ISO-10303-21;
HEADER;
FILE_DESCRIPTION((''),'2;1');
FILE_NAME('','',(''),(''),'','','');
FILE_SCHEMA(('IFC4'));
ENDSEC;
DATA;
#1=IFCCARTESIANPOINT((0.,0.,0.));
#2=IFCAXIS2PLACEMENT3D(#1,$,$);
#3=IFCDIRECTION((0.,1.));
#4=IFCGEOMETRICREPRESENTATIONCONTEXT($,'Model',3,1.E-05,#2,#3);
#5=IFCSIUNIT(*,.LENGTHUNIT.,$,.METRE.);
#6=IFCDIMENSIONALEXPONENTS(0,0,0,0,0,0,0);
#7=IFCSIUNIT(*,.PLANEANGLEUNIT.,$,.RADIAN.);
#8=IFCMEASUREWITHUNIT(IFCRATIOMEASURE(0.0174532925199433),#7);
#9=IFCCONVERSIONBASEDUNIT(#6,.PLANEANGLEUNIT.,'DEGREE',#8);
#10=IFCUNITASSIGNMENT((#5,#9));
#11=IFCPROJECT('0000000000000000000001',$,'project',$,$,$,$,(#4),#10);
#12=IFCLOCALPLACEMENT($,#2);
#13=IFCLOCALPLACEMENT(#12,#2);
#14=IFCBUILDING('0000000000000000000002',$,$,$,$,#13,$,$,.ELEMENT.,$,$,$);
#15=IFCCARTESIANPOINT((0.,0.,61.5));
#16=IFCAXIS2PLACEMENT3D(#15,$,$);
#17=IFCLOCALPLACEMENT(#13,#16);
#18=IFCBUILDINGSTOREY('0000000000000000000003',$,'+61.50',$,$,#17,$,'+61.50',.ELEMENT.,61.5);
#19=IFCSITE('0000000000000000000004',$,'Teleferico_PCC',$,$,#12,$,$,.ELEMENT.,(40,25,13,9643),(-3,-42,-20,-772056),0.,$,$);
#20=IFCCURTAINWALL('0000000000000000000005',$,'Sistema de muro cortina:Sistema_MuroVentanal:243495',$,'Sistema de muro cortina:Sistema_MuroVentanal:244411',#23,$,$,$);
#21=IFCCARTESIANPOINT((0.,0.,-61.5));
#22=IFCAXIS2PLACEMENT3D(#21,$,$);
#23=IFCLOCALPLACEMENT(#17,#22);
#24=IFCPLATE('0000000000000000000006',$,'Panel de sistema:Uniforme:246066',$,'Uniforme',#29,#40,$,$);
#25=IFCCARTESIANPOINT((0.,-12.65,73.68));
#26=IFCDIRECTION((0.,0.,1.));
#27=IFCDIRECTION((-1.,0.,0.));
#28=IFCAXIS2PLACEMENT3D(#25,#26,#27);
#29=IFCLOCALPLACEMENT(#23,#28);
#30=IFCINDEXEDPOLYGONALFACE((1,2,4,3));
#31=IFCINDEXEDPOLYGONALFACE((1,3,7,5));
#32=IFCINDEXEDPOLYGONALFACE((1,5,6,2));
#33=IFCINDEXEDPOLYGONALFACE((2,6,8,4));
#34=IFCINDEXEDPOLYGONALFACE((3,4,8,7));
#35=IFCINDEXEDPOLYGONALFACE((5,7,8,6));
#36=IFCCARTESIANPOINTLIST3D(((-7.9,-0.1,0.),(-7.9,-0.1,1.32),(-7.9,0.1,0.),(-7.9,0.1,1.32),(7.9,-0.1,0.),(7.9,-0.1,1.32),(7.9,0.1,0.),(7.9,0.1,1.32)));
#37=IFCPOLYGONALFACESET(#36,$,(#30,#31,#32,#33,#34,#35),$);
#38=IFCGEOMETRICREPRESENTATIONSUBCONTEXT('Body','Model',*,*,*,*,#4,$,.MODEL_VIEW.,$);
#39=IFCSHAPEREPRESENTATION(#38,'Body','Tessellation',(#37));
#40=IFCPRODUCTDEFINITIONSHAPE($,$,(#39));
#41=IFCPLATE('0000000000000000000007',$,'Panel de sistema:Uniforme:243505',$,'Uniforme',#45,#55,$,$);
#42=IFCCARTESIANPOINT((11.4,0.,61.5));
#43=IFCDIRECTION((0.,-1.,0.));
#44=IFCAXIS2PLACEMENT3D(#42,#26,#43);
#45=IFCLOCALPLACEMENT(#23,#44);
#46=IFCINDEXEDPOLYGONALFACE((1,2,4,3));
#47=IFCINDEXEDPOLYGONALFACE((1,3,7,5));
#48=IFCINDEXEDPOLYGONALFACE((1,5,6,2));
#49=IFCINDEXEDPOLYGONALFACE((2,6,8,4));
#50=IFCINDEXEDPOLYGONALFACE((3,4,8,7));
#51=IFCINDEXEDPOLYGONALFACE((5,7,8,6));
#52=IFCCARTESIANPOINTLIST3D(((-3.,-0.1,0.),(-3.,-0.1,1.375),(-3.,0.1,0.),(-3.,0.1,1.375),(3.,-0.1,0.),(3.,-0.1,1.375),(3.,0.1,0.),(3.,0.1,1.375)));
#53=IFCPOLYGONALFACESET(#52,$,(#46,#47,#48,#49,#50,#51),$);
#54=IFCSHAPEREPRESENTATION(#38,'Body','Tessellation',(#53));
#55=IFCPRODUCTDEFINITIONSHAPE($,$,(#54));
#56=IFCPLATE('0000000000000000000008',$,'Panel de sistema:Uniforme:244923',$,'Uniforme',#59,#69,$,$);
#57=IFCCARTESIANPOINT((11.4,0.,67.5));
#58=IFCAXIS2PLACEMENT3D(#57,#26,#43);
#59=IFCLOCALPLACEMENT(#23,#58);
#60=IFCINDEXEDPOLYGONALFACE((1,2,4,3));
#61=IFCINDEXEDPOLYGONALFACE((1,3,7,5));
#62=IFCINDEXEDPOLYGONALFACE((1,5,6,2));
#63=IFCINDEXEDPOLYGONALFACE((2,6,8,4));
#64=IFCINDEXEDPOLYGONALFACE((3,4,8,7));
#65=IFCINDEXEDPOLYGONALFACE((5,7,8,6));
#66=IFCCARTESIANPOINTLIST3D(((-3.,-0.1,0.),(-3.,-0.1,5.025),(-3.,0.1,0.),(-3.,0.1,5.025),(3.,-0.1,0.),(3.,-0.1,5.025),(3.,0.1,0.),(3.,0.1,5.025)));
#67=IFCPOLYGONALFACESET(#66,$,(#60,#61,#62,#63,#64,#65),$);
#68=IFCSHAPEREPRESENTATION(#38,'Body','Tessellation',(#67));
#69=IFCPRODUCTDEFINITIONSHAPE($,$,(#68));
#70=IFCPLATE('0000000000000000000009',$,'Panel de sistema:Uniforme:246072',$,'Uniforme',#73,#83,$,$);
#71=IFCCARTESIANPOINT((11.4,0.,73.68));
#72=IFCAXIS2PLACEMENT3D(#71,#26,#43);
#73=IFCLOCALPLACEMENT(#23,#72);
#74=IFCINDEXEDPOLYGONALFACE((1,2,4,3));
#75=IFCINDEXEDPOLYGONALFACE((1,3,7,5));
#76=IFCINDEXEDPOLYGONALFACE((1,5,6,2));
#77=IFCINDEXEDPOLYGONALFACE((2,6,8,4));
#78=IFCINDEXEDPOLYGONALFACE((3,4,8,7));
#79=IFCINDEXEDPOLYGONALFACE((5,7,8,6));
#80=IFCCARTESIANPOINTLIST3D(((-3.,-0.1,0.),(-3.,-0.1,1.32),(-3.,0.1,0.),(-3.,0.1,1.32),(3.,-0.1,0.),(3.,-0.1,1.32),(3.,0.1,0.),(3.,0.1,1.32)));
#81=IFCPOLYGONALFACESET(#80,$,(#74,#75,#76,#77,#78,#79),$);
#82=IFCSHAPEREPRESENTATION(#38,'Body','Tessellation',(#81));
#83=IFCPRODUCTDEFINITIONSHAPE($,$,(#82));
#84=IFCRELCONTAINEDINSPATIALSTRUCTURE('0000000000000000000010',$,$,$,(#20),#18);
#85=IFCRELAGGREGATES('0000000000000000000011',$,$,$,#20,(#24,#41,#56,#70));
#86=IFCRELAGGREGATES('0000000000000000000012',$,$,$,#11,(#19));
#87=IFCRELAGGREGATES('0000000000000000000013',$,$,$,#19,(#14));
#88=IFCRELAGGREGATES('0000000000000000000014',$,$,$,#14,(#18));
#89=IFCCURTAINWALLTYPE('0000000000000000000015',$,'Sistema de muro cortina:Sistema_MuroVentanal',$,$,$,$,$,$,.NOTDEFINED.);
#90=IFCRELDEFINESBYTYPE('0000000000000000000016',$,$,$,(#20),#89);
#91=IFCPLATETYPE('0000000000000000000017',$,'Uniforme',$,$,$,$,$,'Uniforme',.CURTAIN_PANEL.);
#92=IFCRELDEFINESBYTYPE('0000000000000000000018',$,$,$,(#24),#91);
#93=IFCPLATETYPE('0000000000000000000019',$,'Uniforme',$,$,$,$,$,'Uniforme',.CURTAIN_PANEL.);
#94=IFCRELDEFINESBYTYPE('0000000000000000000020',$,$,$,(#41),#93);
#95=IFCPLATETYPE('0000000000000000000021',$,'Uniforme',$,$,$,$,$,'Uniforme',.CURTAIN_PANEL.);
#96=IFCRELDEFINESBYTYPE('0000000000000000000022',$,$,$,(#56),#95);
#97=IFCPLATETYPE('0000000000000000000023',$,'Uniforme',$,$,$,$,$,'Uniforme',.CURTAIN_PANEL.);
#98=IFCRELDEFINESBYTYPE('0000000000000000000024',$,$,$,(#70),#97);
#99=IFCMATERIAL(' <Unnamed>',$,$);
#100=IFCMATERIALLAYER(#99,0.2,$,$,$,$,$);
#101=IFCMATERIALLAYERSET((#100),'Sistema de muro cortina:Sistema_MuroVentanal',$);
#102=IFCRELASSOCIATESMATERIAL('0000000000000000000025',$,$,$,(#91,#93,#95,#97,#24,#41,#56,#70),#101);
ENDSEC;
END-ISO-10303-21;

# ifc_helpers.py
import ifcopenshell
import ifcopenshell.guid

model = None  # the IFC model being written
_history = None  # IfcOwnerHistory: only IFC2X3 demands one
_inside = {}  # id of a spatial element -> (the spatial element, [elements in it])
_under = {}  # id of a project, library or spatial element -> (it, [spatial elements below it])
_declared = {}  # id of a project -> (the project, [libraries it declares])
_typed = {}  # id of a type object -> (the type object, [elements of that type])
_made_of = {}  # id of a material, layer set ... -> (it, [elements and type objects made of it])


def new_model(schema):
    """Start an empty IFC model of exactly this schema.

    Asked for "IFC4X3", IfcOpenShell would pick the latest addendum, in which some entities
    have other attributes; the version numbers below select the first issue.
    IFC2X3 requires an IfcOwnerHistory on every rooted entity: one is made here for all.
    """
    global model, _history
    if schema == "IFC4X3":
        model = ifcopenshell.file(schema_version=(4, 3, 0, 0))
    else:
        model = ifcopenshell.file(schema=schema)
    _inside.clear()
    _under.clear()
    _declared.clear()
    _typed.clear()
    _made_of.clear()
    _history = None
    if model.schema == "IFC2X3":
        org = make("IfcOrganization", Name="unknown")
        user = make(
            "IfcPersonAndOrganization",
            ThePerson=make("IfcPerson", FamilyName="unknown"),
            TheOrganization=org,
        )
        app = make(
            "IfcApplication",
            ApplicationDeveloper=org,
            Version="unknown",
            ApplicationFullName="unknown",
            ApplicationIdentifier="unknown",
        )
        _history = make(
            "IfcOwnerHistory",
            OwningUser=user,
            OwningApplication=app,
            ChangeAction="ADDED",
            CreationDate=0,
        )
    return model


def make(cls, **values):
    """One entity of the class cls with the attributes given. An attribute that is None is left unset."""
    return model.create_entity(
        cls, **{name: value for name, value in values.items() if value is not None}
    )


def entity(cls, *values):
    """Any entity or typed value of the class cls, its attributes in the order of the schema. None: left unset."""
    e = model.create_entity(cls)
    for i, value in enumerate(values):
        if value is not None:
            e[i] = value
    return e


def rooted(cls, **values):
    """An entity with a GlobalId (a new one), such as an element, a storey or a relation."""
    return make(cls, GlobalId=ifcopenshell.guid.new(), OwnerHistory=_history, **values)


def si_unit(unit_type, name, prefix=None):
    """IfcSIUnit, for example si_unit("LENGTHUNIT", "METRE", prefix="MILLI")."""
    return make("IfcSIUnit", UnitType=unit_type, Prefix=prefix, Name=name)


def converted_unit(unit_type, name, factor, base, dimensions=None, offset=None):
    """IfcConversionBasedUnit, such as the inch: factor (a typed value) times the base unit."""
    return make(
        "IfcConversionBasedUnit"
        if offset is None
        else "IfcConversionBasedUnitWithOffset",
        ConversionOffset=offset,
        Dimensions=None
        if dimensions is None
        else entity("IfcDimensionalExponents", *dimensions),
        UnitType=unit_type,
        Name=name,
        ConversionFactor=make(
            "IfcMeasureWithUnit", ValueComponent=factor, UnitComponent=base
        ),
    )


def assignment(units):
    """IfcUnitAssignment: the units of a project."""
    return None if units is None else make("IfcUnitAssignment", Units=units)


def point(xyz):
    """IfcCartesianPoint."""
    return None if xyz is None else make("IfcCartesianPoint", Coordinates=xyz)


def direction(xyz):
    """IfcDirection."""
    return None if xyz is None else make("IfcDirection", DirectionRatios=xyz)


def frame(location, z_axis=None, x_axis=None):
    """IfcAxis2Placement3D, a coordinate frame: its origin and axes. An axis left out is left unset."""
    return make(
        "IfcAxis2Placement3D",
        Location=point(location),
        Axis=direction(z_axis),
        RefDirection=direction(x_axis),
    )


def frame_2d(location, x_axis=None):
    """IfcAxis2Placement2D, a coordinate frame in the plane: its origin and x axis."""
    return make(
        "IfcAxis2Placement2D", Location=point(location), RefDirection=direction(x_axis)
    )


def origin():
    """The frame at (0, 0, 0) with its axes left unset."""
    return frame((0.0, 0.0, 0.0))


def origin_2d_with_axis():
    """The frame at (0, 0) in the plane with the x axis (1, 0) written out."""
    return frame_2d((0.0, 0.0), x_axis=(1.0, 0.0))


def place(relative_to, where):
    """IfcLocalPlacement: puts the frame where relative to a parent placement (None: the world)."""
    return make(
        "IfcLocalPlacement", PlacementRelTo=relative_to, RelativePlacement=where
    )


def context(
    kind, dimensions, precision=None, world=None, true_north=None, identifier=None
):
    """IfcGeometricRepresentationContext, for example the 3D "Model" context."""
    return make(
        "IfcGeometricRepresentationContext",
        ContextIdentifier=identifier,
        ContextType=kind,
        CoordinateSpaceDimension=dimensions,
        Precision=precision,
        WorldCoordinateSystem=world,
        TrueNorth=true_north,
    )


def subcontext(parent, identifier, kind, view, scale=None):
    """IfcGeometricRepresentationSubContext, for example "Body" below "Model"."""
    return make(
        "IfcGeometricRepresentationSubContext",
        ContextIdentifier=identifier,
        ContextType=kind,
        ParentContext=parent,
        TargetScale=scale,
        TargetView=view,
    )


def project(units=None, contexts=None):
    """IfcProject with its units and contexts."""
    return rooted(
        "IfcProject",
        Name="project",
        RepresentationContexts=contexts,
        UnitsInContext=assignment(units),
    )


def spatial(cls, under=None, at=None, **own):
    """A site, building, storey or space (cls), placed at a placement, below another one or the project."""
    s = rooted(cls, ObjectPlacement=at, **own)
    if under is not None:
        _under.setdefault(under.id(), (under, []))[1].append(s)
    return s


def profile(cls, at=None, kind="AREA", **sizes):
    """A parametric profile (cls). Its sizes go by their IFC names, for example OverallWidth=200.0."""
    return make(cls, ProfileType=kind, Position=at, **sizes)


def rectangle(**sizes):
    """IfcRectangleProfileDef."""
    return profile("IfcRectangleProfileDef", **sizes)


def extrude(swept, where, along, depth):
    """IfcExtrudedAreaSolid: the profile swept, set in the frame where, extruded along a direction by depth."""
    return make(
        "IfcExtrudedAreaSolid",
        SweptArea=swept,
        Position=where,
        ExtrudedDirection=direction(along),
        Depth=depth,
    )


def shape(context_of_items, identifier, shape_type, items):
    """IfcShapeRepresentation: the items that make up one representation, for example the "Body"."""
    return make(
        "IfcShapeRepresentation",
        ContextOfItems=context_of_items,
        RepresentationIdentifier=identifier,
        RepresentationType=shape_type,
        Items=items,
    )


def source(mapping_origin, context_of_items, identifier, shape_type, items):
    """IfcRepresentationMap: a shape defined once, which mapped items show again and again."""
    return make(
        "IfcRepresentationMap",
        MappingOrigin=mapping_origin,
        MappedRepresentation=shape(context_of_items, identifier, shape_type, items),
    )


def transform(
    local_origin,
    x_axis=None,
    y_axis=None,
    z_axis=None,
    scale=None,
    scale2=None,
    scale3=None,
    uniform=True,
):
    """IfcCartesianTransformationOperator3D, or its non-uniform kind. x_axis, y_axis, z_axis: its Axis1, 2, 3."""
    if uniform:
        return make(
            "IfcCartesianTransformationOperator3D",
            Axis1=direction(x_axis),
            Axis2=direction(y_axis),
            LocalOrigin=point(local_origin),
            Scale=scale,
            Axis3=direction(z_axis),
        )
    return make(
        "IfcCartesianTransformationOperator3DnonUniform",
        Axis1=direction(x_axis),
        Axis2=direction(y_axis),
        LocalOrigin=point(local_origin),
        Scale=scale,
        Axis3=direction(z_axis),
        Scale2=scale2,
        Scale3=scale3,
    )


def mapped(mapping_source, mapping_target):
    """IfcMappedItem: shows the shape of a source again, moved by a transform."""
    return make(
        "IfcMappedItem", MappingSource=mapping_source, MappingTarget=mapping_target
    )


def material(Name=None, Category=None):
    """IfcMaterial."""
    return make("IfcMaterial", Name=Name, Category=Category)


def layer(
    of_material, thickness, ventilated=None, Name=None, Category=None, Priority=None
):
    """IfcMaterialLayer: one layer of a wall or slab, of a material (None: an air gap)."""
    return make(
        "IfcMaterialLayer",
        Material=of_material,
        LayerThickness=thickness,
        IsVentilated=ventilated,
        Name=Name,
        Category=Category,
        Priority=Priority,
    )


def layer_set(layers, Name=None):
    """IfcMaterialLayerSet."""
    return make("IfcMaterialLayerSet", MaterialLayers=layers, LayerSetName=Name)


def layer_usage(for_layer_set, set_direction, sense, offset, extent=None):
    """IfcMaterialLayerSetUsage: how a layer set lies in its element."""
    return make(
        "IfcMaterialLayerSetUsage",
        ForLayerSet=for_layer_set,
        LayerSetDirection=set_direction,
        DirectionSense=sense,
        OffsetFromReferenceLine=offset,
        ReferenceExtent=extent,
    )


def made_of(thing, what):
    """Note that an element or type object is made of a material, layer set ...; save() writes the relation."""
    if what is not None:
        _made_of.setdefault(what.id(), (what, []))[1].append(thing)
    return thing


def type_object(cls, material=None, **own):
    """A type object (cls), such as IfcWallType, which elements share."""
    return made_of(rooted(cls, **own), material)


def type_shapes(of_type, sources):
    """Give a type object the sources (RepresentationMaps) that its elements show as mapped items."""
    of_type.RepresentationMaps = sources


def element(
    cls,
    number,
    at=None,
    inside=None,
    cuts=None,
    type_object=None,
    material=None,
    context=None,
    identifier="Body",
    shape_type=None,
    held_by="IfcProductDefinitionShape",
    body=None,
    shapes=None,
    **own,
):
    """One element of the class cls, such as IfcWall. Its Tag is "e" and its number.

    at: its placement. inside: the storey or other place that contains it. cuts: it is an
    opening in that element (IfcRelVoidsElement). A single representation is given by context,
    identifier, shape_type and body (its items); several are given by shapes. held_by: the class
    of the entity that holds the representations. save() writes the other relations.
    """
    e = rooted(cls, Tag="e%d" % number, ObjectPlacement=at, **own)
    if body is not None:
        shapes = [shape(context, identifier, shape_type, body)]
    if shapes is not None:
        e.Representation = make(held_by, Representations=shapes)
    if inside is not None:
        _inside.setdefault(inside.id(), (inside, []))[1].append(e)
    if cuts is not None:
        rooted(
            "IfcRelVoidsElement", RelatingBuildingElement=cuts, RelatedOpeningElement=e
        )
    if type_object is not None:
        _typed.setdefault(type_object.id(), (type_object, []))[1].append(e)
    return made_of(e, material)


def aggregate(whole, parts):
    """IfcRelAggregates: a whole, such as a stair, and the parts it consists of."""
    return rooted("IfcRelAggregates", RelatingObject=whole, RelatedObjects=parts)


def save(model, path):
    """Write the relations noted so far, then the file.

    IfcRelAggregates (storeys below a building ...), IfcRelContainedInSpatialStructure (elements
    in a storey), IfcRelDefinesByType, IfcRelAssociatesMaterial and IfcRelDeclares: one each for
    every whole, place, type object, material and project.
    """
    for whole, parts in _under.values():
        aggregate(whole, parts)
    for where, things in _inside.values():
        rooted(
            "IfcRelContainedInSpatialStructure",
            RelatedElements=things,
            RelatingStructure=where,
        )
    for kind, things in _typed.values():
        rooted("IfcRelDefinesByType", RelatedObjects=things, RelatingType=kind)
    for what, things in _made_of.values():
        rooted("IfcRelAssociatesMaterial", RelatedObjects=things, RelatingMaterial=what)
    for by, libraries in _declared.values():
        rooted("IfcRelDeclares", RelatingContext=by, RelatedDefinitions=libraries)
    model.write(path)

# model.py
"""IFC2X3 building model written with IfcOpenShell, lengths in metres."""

from ifc_helpers import new_model, entity, si_unit, converted_unit, direction, frame, origin, origin_2d_with_axis, place, context, subcontext, project, spatial, rectangle, extrude, source, transform, mapped, material, layer, layer_set, layer_usage, type_object, type_shapes, element, aggregate, save


model = new_model("IFC2X3")

# Units and contexts
model_context = context("Model", 3, precision=1e-05, world=origin(), true_north=direction((0.0, 1.0)))
body_context = subcontext(model_context, "Body", "Model", "MODEL_VIEW")
ifc_project = project(units=[si_unit("LENGTHUNIT", "METRE"), converted_unit("PLANEANGLEUNIT", "DEGREE", entity("IfcRatioMeasure", 0.0174532925199433), si_unit("PLANEANGLEUNIT", "RADIAN"), dimensions=[0, 0, 0, 0, 0, 0, 0])], contexts=[model_context])

# Site, building, storey
site_placement = place(None, origin())
site = spatial("IfcSite", under=ifc_project, at=site_placement, Name="Teleferico_PCC", CompositionType="ELEMENT", RefLatitude=(40, 25, 13, 9643), RefLongitude=(-3, -42, -20, -772056), RefElevation=0.0)
building_placement = place(site_placement, origin())
building = spatial("IfcBuilding", under=site, at=building_placement, CompositionType="ELEMENT")
storey_placement = place(building_placement, frame((0.0, 0.0, 61.5)))
storey = spatial("IfcBuildingStorey", under=building, at=storey_placement, Name="+61.50", LongName="+61.50", CompositionType="ELEMENT", Elevation=61.5)

# Curtain wall, plates
curtain_wall_type = type_object("IfcCurtainWallType", Name="Sistema de muro cortina:Sistema_MuroVentanal", PredefinedType="NOTDEFINED")
curtain_wall_placement = place(storey_placement, frame((0.0, 0.0, -61.5)))
curtain_wall = element("IfcCurtainWall", 1, at=curtain_wall_placement, inside=storey, type_object=curtain_wall_type, Name="Sistema de muro cortina:Sistema_MuroVentanal:243495", ObjectType="Sistema de muro cortina:Sistema_MuroVentanal:244411")
ifc_material = material(Name=" <Unnamed>")
ifc_layer_1 = layer(ifc_material, 0.2)
ifc_layer_set_1 = layer_set([ifc_layer_1], Name="Sistema de muro cortina:Sistema_MuroVentanal")
ifc_layer_usage_1 = layer_usage(ifc_layer_set_1, "AXIS3", "POSITIVE", 0.0)
plate_type_1 = type_object("IfcPlateType", Name="Uniforme", ElementType="Uniforme", PredefinedType="CURTAIN_PANEL", material=ifc_layer_set_1)
shared_shape_1 = source(origin(), body_context, "Body", "SweptSolid", [
    extrude(rectangle(XDim=0.2, YDim=15.8, at=origin_2d_with_axis()), frame((0.0, 0.0, 0.0), z_axis=(0.0, 0.0, 1.0), x_axis=(0.0, 1.0, 0.0)), (0.0, 0.0, 1.0), 1.32),
])
type_shapes(plate_type_1, [shared_shape_1])
plate_1_placement = place(curtain_wall_placement, frame((0.0, -12.65, 73.68), z_axis=(0.0, 0.0, 1.0), x_axis=(-1.0, 0.0, 0.0)))
plate_1 = element("IfcPlate", 2, at=plate_1_placement, type_object=plate_type_1, material=ifc_layer_usage_1, Name="Panel de sistema:Uniforme:246066", ObjectType="Uniforme", context=body_context, shape_type="MappedRepresentation", body=[
    mapped(shared_shape_1, transform((0.0, 0.0, 0.0), scale=1.0)),
])
ifc_layer_usage_2 = layer_usage(ifc_layer_set_1, "AXIS3", "POSITIVE", 0.0)
plate_type_2 = type_object("IfcPlateType", Name="Uniforme", ElementType="Uniforme", PredefinedType="CURTAIN_PANEL", material=ifc_layer_set_1)
shared_shape_2 = source(origin(), body_context, "Body", "SweptSolid", [
    extrude(rectangle(XDim=0.2, YDim=6.0, at=origin_2d_with_axis()), frame((0.0, 0.0, 0.0), z_axis=(0.0, 0.0, 1.0), x_axis=(0.0, 1.0, 0.0)), (0.0, 0.0, 1.0), 1.375),
])
type_shapes(plate_type_2, [shared_shape_2])
plate_2_placement = place(curtain_wall_placement, frame((11.4, 0.0, 61.5), z_axis=(0.0, 0.0, 1.0), x_axis=(0.0, -1.0, 0.0)))
plate_2 = element("IfcPlate", 3, at=plate_2_placement, type_object=plate_type_2, material=ifc_layer_usage_2, Name="Panel de sistema:Uniforme:243505", ObjectType="Uniforme", context=body_context, shape_type="MappedRepresentation", body=[
    mapped(shared_shape_2, transform((0.0, 0.0, 0.0), scale=1.0)),
])
ifc_layer_usage_3 = layer_usage(ifc_layer_set_1, "AXIS3", "POSITIVE", 0.0)
plate_type_3 = type_object("IfcPlateType", Name="Uniforme", ElementType="Uniforme", PredefinedType="CURTAIN_PANEL", material=ifc_layer_set_1)
shared_shape_3 = source(origin(), body_context, "Body", "SweptSolid", [
    extrude(rectangle(XDim=0.2, YDim=6.0, at=origin_2d_with_axis()), frame((0.0, 0.0, 0.0), z_axis=(0.0, 0.0, 1.0), x_axis=(0.0, 1.0, 0.0)), (0.0, 0.0, 1.0), 5.025),
])
type_shapes(plate_type_3, [shared_shape_3])
plate_3_placement = place(curtain_wall_placement, frame((11.4, 0.0, 67.5), z_axis=(0.0, 0.0, 1.0), x_axis=(0.0, -1.0, 0.0)))
plate_3 = element("IfcPlate", 4, at=plate_3_placement, type_object=plate_type_3, material=ifc_layer_usage_3, Name="Panel de sistema:Uniforme:244923", ObjectType="Uniforme", context=body_context, shape_type="MappedRepresentation", body=[
    mapped(shared_shape_3, transform((0.0, 0.0, 0.0), scale=1.0)),
])
ifc_layer_usage_4 = layer_usage(ifc_layer_set_1, "AXIS3", "POSITIVE", 0.0)
plate_type_4 = type_object("IfcPlateType", Name="Uniforme", ElementType="Uniforme", PredefinedType="CURTAIN_PANEL", material=ifc_layer_set_1)
shared_shape_4 = source(origin(), body_context, "Body", "SweptSolid", [
    extrude(rectangle(XDim=0.2, YDim=6.0, at=origin_2d_with_axis()), frame((0.0, 0.0, 0.0), z_axis=(0.0, 0.0, 1.0), x_axis=(0.0, 1.0, 0.0)), (0.0, 0.0, 1.0), 1.32),
])
type_shapes(plate_type_4, [shared_shape_4])
plate_4_placement = place(curtain_wall_placement, frame((11.4, 0.0, 73.68), z_axis=(0.0, 0.0, 1.0), x_axis=(0.0, -1.0, 0.0)))
plate_4 = element("IfcPlate", 5, at=plate_4_placement, type_object=plate_type_4, material=ifc_layer_usage_4, Name="Panel de sistema:Uniforme:246072", ObjectType="Uniforme", context=body_context, shape_type="MappedRepresentation", body=[
    mapped(shared_shape_4, transform((0.0, 0.0, 0.0), scale=1.0)),
])
aggregate(curtain_wall, [plate_1, plate_2, plate_3, plate_4])

save(model, "model.ifc")
